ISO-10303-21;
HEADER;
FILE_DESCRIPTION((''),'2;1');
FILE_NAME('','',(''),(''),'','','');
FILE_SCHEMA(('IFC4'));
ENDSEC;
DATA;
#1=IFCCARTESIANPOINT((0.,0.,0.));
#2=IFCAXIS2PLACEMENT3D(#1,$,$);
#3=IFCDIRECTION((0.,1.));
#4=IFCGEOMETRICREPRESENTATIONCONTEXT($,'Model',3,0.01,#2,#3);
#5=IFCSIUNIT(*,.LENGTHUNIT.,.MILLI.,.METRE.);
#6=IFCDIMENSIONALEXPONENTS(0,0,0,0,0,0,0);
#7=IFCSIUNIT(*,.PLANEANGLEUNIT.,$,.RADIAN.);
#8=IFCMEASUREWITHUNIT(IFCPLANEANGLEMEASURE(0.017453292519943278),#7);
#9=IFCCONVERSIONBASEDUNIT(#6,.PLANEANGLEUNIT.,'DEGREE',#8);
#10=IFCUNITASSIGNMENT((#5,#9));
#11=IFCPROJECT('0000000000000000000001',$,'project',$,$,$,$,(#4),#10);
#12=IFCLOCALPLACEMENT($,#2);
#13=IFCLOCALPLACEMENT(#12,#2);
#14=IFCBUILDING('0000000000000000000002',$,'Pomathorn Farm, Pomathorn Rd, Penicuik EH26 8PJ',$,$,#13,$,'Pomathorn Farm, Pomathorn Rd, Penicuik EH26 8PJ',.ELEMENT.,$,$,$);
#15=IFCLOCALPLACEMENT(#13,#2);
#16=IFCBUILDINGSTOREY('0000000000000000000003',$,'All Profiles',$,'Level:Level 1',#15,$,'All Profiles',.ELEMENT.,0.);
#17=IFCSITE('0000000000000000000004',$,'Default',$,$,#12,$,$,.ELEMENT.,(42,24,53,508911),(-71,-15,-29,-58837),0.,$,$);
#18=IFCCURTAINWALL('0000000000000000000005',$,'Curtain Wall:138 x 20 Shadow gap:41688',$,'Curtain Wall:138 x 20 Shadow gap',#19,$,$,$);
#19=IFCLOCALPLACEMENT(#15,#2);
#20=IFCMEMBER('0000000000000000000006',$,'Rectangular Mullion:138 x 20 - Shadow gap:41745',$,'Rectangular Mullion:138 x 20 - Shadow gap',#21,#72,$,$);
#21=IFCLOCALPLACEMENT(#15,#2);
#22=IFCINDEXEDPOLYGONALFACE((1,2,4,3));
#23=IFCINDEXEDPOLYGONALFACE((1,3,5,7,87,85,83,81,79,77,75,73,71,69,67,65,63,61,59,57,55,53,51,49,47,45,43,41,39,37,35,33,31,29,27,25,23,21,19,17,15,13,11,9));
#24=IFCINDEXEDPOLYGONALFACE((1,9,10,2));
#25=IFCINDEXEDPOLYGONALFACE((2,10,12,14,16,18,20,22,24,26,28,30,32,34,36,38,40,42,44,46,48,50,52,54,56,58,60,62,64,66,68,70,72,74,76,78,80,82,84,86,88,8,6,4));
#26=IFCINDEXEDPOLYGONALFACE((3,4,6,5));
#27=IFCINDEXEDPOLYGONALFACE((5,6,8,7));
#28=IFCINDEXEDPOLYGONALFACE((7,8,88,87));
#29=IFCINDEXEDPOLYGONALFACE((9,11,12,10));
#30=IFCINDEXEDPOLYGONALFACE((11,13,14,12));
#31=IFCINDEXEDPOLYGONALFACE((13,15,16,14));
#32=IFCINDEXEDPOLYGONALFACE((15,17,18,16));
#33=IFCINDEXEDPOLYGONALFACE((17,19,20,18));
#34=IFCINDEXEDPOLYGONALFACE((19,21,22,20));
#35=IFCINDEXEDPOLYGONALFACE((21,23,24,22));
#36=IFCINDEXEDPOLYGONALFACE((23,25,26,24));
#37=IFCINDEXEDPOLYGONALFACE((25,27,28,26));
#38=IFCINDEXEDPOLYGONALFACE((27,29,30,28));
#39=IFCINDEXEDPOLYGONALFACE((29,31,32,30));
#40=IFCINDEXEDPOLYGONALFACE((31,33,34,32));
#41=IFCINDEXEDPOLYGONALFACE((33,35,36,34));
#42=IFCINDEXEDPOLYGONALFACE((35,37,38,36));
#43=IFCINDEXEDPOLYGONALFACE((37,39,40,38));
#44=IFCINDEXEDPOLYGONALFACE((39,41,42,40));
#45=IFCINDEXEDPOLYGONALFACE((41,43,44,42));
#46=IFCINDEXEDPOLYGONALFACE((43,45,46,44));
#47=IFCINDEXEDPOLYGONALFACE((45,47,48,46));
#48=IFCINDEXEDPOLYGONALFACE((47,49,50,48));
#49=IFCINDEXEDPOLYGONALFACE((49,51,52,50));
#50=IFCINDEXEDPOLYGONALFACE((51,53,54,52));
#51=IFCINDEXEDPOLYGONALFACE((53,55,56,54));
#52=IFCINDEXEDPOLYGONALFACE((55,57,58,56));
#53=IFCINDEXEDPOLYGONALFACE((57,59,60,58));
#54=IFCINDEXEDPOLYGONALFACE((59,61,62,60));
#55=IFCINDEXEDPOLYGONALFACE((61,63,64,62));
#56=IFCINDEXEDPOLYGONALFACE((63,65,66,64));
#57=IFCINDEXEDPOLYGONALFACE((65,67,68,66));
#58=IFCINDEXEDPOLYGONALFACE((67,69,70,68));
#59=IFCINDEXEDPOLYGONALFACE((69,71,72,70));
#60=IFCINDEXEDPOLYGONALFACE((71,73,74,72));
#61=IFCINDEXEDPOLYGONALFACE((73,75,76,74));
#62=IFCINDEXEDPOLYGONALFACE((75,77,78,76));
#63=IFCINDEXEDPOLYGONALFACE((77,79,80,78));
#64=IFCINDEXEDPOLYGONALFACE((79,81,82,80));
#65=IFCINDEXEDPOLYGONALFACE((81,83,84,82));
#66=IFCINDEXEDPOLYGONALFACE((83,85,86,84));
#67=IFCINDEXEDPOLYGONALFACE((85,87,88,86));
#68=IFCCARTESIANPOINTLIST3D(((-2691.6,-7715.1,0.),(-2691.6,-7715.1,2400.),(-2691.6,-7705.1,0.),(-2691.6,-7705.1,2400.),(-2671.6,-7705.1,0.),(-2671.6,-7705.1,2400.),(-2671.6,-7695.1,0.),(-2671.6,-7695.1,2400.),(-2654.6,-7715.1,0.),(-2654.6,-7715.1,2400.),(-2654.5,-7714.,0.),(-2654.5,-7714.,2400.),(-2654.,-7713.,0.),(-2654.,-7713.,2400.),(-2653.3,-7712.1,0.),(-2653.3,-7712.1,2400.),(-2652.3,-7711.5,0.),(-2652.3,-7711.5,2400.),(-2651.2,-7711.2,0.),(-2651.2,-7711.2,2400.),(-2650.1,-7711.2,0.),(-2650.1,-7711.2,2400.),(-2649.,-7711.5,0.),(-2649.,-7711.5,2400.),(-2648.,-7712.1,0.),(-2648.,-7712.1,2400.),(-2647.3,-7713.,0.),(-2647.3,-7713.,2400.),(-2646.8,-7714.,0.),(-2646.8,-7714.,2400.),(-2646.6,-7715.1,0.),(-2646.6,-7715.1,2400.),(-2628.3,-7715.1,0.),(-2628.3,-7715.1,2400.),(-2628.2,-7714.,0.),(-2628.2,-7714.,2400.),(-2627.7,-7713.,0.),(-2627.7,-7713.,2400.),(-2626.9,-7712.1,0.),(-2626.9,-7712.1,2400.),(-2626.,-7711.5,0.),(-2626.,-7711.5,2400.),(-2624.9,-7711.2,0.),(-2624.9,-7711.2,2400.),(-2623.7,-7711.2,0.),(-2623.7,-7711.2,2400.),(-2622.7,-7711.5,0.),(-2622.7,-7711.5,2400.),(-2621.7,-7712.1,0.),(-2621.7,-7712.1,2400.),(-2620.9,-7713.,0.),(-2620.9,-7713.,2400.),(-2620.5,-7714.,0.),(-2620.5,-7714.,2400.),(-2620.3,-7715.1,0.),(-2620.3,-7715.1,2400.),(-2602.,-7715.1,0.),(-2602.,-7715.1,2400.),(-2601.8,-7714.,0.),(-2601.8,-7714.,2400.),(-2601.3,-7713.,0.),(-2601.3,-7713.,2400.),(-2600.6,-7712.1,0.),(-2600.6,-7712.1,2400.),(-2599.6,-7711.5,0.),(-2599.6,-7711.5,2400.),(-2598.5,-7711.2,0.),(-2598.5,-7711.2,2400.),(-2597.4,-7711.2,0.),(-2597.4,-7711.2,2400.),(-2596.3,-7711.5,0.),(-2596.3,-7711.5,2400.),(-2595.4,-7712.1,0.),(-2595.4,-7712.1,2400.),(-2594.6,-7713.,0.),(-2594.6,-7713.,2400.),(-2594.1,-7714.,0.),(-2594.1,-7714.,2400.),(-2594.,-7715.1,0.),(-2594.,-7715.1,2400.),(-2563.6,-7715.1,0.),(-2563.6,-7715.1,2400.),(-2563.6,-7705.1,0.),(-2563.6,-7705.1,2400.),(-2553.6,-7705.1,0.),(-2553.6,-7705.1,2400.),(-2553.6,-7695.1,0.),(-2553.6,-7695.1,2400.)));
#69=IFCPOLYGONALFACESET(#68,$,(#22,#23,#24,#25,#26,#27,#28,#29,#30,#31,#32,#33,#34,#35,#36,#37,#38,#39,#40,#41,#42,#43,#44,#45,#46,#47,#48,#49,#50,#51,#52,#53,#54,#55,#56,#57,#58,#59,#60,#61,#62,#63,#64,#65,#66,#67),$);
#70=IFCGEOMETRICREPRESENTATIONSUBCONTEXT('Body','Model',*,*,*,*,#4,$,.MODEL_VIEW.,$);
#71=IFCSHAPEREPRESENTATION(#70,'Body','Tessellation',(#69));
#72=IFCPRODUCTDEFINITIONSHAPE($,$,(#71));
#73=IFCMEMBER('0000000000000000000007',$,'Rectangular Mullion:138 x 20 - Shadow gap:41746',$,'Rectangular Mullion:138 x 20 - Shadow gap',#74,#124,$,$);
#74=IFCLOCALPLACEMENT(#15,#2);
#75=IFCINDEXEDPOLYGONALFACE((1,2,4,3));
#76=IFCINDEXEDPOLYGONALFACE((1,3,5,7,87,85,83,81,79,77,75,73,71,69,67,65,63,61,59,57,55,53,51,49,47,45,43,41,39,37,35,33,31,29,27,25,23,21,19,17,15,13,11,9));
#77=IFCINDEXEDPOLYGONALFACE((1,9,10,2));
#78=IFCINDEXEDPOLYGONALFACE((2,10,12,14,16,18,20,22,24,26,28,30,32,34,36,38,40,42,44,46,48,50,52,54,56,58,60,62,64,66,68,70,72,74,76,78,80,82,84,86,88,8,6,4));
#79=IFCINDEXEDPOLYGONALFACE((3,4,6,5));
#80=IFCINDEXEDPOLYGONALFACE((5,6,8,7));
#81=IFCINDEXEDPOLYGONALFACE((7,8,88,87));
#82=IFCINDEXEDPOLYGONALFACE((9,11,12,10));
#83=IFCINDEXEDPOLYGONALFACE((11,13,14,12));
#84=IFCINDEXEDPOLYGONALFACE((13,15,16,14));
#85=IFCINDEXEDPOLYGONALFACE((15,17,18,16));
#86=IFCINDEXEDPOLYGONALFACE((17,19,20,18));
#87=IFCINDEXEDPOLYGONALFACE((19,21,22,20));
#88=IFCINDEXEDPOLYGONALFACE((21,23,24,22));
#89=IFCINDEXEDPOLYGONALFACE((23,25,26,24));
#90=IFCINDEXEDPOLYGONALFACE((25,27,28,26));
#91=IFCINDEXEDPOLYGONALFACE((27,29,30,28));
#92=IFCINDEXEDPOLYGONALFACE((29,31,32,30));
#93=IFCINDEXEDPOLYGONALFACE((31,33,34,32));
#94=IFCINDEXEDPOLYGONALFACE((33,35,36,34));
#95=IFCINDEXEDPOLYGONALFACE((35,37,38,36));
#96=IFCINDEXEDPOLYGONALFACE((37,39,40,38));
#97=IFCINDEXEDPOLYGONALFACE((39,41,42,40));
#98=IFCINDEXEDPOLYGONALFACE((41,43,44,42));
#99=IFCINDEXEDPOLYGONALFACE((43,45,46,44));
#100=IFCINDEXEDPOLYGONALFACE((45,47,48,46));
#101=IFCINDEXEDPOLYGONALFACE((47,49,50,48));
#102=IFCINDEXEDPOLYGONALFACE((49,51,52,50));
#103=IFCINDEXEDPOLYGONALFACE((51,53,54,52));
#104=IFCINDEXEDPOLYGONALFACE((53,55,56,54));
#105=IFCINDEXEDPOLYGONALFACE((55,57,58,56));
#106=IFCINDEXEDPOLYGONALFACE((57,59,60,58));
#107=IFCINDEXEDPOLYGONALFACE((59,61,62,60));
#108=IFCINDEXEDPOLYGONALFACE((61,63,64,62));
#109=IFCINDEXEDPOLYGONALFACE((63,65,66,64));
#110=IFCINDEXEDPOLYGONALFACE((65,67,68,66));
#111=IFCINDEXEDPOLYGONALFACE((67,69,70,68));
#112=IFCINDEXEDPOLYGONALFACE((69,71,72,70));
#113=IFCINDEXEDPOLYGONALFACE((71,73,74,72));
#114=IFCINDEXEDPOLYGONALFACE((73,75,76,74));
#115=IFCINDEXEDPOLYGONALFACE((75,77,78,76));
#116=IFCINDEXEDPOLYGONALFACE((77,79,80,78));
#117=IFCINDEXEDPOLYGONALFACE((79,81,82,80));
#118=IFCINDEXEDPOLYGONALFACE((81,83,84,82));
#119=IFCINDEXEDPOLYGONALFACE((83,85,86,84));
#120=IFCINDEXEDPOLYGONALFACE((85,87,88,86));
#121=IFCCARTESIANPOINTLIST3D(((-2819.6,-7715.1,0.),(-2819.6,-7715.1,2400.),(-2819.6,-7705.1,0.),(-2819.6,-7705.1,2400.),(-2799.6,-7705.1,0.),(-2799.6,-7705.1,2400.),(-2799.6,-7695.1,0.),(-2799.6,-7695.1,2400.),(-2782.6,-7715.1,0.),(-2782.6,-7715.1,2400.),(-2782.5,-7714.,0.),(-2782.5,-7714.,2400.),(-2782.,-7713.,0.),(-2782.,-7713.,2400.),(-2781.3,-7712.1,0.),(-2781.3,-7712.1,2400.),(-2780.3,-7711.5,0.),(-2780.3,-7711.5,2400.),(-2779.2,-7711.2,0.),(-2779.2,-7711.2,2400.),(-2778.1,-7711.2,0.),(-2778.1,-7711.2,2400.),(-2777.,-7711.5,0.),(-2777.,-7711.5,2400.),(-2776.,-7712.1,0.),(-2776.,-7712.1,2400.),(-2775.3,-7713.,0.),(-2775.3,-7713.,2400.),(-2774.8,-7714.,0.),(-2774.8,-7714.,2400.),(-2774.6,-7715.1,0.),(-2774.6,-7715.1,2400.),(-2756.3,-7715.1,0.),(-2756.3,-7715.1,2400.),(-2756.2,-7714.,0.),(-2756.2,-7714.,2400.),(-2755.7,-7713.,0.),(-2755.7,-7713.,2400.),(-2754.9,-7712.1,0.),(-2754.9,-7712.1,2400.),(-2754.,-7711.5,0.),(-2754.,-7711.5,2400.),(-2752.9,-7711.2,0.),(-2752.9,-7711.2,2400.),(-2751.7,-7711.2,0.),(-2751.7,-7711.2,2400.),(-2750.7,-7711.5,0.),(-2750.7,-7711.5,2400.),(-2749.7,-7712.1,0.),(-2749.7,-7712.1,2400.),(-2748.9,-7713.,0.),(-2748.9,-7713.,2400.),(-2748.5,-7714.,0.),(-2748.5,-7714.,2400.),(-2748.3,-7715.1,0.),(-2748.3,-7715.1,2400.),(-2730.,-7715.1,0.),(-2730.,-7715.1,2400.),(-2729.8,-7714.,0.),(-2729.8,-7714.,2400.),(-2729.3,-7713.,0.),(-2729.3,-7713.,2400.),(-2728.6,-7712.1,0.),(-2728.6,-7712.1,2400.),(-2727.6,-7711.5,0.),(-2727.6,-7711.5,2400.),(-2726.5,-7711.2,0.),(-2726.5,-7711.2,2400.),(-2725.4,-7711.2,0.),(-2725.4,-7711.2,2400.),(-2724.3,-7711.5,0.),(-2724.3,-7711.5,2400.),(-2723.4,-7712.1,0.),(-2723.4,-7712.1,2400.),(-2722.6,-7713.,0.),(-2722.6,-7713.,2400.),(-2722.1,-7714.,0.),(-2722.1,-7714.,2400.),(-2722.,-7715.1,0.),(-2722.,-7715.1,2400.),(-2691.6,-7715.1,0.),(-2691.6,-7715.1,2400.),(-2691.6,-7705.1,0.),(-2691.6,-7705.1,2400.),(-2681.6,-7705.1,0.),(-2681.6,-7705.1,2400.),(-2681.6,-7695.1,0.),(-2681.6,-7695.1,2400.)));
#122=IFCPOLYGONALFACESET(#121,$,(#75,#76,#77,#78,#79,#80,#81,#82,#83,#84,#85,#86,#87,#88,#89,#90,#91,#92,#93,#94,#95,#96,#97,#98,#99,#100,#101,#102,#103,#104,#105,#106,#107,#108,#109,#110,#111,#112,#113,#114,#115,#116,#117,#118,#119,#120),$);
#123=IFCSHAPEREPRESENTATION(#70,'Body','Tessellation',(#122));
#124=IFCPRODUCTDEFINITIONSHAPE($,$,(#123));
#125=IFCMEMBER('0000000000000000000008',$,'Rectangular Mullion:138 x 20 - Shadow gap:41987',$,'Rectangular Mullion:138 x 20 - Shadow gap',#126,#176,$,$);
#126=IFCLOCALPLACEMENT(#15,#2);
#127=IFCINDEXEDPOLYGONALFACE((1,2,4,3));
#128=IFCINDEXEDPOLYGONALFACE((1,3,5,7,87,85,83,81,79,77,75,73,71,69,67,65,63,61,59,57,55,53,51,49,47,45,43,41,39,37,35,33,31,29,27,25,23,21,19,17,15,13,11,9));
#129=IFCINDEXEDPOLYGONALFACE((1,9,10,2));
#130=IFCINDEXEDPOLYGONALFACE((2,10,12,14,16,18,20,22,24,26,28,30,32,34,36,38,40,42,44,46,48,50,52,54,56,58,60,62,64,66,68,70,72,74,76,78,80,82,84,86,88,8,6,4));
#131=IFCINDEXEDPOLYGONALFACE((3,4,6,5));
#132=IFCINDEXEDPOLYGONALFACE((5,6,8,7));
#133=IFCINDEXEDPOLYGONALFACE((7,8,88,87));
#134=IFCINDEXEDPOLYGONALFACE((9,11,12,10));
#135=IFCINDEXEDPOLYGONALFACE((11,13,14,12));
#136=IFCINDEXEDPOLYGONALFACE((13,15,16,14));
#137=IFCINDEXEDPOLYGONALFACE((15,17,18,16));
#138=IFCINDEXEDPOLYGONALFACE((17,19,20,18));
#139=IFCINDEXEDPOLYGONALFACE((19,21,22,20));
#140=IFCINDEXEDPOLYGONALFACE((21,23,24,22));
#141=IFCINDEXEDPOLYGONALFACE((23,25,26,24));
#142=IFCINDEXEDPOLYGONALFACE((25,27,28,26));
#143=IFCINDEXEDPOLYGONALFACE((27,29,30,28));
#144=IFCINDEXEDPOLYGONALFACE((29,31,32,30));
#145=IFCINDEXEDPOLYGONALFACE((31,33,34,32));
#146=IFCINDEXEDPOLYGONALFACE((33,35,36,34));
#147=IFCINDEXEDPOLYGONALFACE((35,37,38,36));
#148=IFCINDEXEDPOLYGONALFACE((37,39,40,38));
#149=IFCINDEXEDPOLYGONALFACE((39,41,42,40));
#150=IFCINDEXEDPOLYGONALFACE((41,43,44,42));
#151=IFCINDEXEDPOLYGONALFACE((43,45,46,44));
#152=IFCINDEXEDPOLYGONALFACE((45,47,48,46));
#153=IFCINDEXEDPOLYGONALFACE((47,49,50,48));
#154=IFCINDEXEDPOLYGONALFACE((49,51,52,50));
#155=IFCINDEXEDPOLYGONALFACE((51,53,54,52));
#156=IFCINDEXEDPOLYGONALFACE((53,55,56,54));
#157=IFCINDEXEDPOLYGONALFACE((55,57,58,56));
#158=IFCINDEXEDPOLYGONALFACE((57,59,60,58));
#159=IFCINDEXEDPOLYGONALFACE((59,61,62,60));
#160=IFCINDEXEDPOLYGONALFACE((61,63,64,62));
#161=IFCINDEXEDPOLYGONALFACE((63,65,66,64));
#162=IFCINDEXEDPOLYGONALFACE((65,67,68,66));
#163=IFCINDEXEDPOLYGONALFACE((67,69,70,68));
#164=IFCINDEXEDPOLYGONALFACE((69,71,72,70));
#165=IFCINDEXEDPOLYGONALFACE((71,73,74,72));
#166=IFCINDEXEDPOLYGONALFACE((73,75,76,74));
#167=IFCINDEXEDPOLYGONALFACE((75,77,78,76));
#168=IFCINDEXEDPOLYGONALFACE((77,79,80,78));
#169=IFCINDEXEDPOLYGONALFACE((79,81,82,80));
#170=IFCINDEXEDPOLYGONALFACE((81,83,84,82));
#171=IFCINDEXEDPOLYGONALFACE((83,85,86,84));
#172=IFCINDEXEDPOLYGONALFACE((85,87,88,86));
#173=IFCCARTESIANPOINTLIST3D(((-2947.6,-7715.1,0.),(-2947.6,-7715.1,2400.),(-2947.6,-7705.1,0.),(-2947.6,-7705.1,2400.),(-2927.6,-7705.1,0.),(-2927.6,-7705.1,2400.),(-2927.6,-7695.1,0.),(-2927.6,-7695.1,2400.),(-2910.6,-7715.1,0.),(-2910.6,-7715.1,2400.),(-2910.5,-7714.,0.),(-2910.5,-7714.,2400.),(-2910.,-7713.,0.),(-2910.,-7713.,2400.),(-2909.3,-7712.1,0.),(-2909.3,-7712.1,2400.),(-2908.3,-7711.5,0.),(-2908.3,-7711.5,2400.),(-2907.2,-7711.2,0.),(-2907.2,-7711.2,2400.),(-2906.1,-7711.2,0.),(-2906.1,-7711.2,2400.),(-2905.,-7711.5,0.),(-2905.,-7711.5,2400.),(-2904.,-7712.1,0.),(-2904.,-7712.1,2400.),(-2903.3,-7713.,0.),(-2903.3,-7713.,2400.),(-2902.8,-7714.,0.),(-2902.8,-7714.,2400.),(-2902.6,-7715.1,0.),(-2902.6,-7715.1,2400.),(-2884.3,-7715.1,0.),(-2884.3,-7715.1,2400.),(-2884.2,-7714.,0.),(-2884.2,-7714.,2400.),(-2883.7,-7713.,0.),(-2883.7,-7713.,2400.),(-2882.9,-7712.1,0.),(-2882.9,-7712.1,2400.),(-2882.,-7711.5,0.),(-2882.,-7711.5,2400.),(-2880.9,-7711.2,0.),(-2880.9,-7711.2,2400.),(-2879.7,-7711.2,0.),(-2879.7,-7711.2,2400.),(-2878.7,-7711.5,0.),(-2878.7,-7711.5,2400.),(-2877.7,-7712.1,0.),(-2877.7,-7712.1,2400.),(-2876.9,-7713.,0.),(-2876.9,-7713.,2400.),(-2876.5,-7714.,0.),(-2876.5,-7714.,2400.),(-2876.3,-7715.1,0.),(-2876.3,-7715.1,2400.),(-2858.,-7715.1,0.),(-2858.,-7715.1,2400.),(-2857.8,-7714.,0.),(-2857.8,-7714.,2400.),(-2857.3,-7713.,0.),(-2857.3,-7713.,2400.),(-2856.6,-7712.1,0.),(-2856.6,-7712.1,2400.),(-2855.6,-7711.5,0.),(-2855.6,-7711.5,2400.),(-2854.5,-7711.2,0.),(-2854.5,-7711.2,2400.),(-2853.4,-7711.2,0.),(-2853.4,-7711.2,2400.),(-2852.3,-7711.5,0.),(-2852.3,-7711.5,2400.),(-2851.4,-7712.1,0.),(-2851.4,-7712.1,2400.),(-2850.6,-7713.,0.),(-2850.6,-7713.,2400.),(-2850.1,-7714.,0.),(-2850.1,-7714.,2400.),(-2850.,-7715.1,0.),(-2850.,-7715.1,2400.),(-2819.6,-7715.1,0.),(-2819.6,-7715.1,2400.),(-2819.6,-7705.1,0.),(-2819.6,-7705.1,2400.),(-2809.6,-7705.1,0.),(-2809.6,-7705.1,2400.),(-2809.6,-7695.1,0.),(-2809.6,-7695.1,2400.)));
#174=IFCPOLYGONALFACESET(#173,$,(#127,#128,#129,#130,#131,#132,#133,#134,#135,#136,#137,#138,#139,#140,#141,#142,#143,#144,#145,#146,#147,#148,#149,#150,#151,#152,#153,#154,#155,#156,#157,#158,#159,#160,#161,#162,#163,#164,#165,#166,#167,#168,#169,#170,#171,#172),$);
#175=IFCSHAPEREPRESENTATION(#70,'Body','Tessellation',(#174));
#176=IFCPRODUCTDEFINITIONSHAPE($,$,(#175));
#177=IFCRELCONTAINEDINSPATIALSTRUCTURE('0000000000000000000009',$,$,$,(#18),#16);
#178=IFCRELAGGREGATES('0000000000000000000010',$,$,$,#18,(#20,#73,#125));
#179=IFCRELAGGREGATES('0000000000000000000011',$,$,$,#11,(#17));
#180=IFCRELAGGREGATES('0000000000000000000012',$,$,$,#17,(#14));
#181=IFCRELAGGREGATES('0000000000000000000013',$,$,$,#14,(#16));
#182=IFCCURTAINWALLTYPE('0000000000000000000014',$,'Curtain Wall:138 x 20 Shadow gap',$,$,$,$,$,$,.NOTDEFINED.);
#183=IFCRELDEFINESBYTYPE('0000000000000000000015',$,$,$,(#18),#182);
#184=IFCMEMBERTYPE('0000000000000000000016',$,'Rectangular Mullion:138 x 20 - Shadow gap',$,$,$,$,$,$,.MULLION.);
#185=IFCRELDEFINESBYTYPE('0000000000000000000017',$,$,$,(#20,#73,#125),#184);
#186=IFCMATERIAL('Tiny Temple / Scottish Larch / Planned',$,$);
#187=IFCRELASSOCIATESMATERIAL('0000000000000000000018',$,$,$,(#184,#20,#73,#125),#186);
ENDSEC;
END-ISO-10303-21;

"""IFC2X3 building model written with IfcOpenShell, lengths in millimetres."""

from ifc_helpers import new_model, entity, si_unit, converted_unit, direction, frame, frame_2d, origin, place, context, subcontext, project, spatial, polyline, circle_curve, parameter, trimmed, segment, composite_curve, outline, extrude, source, transform, mapped, material, type_object, type_shapes, element, aggregate, save


model = new_model("IFC2X3")

# Units and contexts
model_context = context("Model", 3, precision=0.01, world=origin(), true_north=direction((0.0, 1.0)))
body_context = subcontext(model_context, "Body", "Model", "MODEL_VIEW")
ifc_project = project(units=[si_unit("LENGTHUNIT", "METRE", prefix="MILLI"), converted_unit("PLANEANGLEUNIT", "DEGREE", entity("IfcPlaneAngleMeasure", 0.017453292519943278), si_unit("PLANEANGLEUNIT", "RADIAN"), dimensions=[0, 0, 0, 0, 0, 0, 0])], contexts=[model_context])

# Site, building, storey
site_placement = place(None, origin())
site = spatial("IfcSite", under=ifc_project, at=site_placement, Name="Default", CompositionType="ELEMENT", RefLatitude=(42, 24, 53, 508911), RefLongitude=(-71, -15, -29, -58837), RefElevation=0.0)
building_placement = place(site_placement, origin())
building = spatial("IfcBuilding", under=site, at=building_placement, Name="Pomathorn Farm, Pomathorn Rd, Penicuik EH26 8PJ", LongName="Pomathorn Farm, Pomathorn Rd, Penicuik EH26 8PJ", CompositionType="ELEMENT")
storey_placement = place(building_placement, origin())
storey = spatial("IfcBuildingStorey", under=building, at=storey_placement, Name="All Profiles", ObjectType="Level:Level 1", LongName="All Profiles", CompositionType="ELEMENT", Elevation=0.0)

# Curtain wall, members
curtain_wall_type_1 = type_object("IfcCurtainWallType", Name="Curtain Wall:138 x 20 Shadow gap", PredefinedType="NOTDEFINED")
curtain_wall_1_placement = place(storey_placement, origin())
curtain_wall_1 = element("IfcCurtainWall", 1, at=curtain_wall_1_placement, inside=storey, type_object=curtain_wall_type_1, Name="Curtain Wall:138 x 20 Shadow gap:41688", ObjectType="Curtain Wall:138 x 20 Shadow gap")
ifc_material = material(Name="Tiny Temple / Scottish Larch / Planned")
member_type_1 = type_object("IfcMemberType", Name="Rectangular Mullion:138 x 20 - Shadow gap", PredefinedType="MULLION", material=ifc_material)
shared_shape_1 = source(origin(), body_context, "Body", "SweptSolid", [
    extrude(outline(composite_curve([segment(polyline([(27.9, -5.7), (58.3, -5.7)]), True, "CONTINUOUS"), segment(polyline([(58.3, -5.7), (58.3, 4.3)]), True, "CONTINUOUS"), segment(polyline([(58.3, 4.3), (68.3, 4.3)]), True, "CONTINUOUS"), segment(polyline([(68.3, 4.3), (68.3, 14.3)]), True, "CONTINUOUS"), segment(polyline([(68.3, 14.3), (-49.7, 14.3)]), True, "CONTINUOUS"), segment(polyline([(-49.7, 14.3), (-49.7, 4.3)]), True, "CONTINUOUS"), segment(polyline([(-49.7, 4.3), (-69.7, 4.3)]), True, "CONTINUOUS"), segment(polyline([(-69.7, 4.3), (-69.7, -5.7)]), True, "CONTINUOUS"), segment(polyline([(-69.7, -5.7), (-32.7, -5.7)]), True, "CONTINUOUS"), segment(trimmed(circle_curve(frame_2d((-28.7, -5.7), x_axis=(1.0, 0.0)), 4.0), [parameter(360.0)], [parameter(180.0)], True, "PARAMETER"), False, "CONTINUOUS"), segment(polyline([(-24.7, -5.7), (-6.4, -5.7)]), True, "CONTINUOUS"), segment(trimmed(circle_curve(frame_2d((-2.4, -5.7), x_axis=(1.0, 0.0)), 4.0), [parameter(360.0)], [parameter(180.0)], True, "PARAMETER"), False, "CONTINUOUS"), segment(polyline([(1.6, -5.7), (19.9, -5.7)]), True, "CONTINUOUS"), segment(trimmed(circle_curve(frame_2d((23.9, -5.7), x_axis=(1.0, 0.0)), 4.0), [parameter(360.0)], [parameter(180.0)], True, "PARAMETER"), False, "CONTINUOUS")], self_intersect=False)), frame((-68.3, -5.7, -2400.0), z_axis=(0.0, 0.0, -1.0), x_axis=(1.0, 0.0, 0.0)), (0.0, 0.0, -1.0), 2400.0),
])
type_shapes(member_type_1, [shared_shape_1])
member_1_placement = place(curtain_wall_1_placement, frame((-2553.6, -7715.1, 0.0), z_axis=(0.0, 0.0, -1.0), x_axis=(1.0, 0.0, 0.0)))
member_1 = element("IfcMember", 2, at=member_1_placement, type_object=member_type_1, material=ifc_material, Name="Rectangular Mullion:138 x 20 - Shadow gap:41745", ObjectType="Rectangular Mullion:138 x 20 - Shadow gap", context=body_context, shape_type="MappedRepresentation", body=[
    mapped(shared_shape_1, transform((0.0, 0.0, 0.0), scale=1.0)),
])
member_2_placement = place(curtain_wall_1_placement, frame((-2681.6, -7715.1, 0.0), z_axis=(0.0, 0.0, -1.0), x_axis=(1.0, 0.0, 0.0)))
member_2 = element("IfcMember", 3, at=member_2_placement, type_object=member_type_1, material=ifc_material, Name="Rectangular Mullion:138 x 20 - Shadow gap:41746", ObjectType="Rectangular Mullion:138 x 20 - Shadow gap", context=body_context, shape_type="MappedRepresentation", body=[
    mapped(shared_shape_1, transform((0.0, 0.0, 0.0), scale=1.0)),
])
member_3_placement = place(curtain_wall_1_placement, frame((-2809.6, -7715.1, 0.0), z_axis=(0.0, 0.0, -1.0), x_axis=(1.0, 0.0, 0.0)))
member_3 = element("IfcMember", 4, at=member_3_placement, type_object=member_type_1, material=ifc_material, Name="Rectangular Mullion:138 x 20 - Shadow gap:41987", ObjectType="Rectangular Mullion:138 x 20 - Shadow gap", context=body_context, shape_type="MappedRepresentation", body=[
    mapped(shared_shape_1, transform((0.0, 0.0, 0.0), scale=1.0)),
])
aggregate(curtain_wall_1, [member_1, member_2, member_3])

save(model, "model.ifc")
